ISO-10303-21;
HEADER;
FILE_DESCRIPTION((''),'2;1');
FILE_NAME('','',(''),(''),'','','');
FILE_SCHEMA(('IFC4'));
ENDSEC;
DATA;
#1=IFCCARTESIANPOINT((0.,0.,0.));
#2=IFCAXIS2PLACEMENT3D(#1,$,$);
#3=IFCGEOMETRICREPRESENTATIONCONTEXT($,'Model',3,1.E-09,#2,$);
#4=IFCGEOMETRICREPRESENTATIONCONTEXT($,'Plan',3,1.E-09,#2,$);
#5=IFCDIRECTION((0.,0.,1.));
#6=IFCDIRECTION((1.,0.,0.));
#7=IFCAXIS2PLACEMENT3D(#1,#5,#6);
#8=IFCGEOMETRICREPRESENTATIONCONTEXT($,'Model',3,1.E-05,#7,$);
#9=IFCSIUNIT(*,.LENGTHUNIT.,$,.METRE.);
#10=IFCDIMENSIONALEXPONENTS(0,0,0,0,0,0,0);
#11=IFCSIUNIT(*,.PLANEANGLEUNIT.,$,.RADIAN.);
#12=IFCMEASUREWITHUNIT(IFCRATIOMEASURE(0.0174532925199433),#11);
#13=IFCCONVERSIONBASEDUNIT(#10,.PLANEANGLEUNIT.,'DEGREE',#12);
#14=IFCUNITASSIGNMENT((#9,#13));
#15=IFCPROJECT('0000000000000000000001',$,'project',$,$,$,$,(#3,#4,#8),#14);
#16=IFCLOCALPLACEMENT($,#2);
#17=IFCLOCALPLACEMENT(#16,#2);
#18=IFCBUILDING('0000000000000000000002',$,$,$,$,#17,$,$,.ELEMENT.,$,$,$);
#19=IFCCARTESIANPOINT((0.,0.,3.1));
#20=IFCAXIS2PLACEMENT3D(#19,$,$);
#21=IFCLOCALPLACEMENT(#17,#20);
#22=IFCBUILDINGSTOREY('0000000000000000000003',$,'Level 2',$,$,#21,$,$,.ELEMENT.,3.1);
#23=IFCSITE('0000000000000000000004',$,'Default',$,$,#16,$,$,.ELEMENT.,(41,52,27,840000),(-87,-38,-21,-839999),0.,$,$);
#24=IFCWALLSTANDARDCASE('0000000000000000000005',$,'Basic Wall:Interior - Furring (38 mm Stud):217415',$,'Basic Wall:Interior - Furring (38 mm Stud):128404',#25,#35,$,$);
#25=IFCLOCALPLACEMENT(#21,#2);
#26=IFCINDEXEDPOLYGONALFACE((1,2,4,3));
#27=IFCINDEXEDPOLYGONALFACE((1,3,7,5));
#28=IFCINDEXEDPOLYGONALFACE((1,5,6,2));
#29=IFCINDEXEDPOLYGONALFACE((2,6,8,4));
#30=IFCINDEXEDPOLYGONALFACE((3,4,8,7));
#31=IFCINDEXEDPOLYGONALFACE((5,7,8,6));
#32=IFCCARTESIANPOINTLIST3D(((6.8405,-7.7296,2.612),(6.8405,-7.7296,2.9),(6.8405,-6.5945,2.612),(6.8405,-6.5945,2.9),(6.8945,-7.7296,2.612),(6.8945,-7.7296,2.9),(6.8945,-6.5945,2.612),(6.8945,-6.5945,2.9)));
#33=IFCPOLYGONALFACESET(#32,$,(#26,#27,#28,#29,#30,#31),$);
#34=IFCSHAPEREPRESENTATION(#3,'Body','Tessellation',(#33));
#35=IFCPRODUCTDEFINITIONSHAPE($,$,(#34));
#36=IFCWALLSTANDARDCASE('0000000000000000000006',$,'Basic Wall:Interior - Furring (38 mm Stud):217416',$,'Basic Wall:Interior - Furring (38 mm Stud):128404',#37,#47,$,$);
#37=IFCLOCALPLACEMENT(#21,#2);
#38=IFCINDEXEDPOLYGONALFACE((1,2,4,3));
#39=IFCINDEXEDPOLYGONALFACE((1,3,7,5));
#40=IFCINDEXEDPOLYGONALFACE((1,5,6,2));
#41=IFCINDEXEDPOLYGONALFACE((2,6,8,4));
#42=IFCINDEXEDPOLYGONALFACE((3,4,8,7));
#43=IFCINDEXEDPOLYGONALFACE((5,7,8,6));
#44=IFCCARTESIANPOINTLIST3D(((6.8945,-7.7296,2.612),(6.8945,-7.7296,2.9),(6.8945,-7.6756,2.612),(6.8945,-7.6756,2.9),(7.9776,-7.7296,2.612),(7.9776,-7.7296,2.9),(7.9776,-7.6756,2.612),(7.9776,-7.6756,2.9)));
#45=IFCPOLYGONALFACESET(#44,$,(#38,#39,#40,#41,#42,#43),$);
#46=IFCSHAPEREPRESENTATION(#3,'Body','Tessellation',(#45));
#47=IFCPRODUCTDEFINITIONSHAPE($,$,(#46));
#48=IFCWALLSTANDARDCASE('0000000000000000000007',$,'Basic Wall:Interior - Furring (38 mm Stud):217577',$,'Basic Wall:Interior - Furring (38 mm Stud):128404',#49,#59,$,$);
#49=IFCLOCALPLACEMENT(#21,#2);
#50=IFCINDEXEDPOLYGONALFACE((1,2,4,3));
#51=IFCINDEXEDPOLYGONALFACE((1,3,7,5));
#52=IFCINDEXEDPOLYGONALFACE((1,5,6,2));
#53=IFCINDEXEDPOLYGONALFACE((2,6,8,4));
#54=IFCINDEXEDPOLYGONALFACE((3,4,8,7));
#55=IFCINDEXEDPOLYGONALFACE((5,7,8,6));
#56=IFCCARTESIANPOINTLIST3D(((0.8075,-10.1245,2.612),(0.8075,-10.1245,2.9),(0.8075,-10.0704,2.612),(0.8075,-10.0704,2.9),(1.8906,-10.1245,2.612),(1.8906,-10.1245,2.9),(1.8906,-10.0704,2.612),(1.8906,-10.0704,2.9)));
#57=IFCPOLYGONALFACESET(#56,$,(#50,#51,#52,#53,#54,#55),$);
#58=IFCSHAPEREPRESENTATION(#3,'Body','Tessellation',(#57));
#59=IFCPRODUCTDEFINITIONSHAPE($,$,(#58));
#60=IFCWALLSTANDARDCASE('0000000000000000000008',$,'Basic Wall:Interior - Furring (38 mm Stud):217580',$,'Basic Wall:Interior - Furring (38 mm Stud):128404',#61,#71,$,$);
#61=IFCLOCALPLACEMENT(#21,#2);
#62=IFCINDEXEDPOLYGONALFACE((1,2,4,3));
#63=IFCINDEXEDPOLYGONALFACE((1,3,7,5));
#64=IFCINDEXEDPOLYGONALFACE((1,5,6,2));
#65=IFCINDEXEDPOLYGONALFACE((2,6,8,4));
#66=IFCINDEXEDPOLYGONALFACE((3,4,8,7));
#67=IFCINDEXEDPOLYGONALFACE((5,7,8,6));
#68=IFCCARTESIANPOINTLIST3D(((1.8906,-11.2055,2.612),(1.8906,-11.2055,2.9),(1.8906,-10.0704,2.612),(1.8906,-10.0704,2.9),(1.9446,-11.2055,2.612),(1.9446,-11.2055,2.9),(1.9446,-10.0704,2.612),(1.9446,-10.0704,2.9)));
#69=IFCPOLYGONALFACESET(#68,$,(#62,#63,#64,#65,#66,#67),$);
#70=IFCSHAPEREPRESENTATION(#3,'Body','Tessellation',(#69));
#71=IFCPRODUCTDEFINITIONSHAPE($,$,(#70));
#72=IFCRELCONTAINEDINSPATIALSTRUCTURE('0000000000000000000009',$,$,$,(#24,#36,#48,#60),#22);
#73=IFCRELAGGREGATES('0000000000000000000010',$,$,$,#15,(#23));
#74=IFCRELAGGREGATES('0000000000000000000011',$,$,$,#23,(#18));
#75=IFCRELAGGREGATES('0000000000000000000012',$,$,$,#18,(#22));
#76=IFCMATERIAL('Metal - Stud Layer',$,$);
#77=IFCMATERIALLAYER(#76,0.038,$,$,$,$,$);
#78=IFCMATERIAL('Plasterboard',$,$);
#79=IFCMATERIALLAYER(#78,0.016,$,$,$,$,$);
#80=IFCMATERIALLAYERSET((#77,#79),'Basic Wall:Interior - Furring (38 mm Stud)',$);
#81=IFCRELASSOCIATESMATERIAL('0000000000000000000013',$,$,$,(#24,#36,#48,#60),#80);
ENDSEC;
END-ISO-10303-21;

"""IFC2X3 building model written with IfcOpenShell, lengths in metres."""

from ifc_helpers import new_model, entity, si_unit, converted_unit, frame, frame_2d, origin, origin_with_axes, place, context, project, spatial, rectangle, extrude, material, layer, layer_set, layer_usage, element, save


model = new_model("IFC2X3")

# Units and contexts
model_context_1 = context("Model", 3, precision=1e-09, world=origin())
plan_context = context("Plan", 3, precision=1e-09, world=origin())
model_context_2 = context("Model", 3, precision=1e-05, world=origin_with_axes())
ifc_project = project(units=[si_unit("LENGTHUNIT", "METRE"), converted_unit("PLANEANGLEUNIT", "DEGREE", entity("IfcRatioMeasure", 0.0174532925199433), si_unit("PLANEANGLEUNIT", "RADIAN"), dimensions=[0, 0, 0, 0, 0, 0, 0])], contexts=[model_context_1, plan_context, model_context_2])

# Site, building, storey
site_placement = place(None, origin())
site = spatial("IfcSite", under=ifc_project, at=site_placement, Name="Default", CompositionType="ELEMENT", RefLatitude=(41, 52, 27, 840000), RefLongitude=(-87, -38, -21, -839999), RefElevation=0.0)
building_placement = place(site_placement, origin())
building = spatial("IfcBuilding", under=site, at=building_placement, CompositionType="ELEMENT")
storey_placement = place(building_placement, frame((0.0, 0.0, 3.1)))
storey = spatial("IfcBuildingStorey", under=building, at=storey_placement, Name="Level 2", CompositionType="ELEMENT", Elevation=3.1)

# Shared definitions
ifc_material_1 = material(Name="Plasterboard")
ifc_material_2 = material(Name="Metal - Stud Layer")

# Walls
ifc_layer_1 = layer(ifc_material_2, 0.038)
ifc_layer_2 = layer(ifc_material_1, 0.016)
ifc_layer_set_1 = layer_set([ifc_layer_1, ifc_layer_2], Name="Basic Wall:Interior - Furring (38 mm Stud)")
ifc_layer_usage_1 = layer_usage(ifc_layer_set_1, "AXIS2", "NEGATIVE", 0.027)
wall_1_placement = place(storey_placement, frame((6.8675, -7.7296, 2.612), z_axis=(0.0, 0.0, 1.0), x_axis=(0.0, 1.0, 0.0)))
element("IfcWallStandardCase", 1, at=wall_1_placement, inside=storey, material=ifc_layer_usage_1, Name="Basic Wall:Interior - Furring (38 mm Stud):217415", ObjectType="Basic Wall:Interior - Furring (38 mm Stud):128404", context=model_context_1, shape_type="SweptSolid", body=[
    extrude(rectangle(XDim=1.1351, YDim=0.054, at=frame_2d((0.5675, 0.0), x_axis=(-1.0, 0.0))), origin(), (0.0, 0.0, 1.0), 0.288),
])
ifc_layer_usage_2 = layer_usage(ifc_layer_set_1, "AXIS2", "NEGATIVE", 0.027)
wall_2_placement = place(storey_placement, frame((7.9776, -7.7026, 2.612), z_axis=(0.0, 0.0, 1.0), x_axis=(-1.0, 0.0, 0.0)))
element("IfcWallStandardCase", 2, at=wall_2_placement, inside=storey, material=ifc_layer_usage_2, Name="Basic Wall:Interior - Furring (38 mm Stud):217416", ObjectType="Basic Wall:Interior - Furring (38 mm Stud):128404", context=model_context_1, shape_type="SweptSolid", body=[
    extrude(rectangle(XDim=1.0831, YDim=0.054, at=frame_2d((0.5415, 0.0), x_axis=(-1.0, 0.0))), origin(), (0.0, 0.0, 1.0), 0.288),
])
ifc_layer_usage_3 = layer_usage(ifc_layer_set_1, "AXIS2", "NEGATIVE", 0.027)
wall_3_placement = place(storey_placement, frame((0.8075, -10.0975, 2.612)))
element("IfcWallStandardCase", 3, at=wall_3_placement, inside=storey, material=ifc_layer_usage_3, Name="Basic Wall:Interior - Furring (38 mm Stud):217577", ObjectType="Basic Wall:Interior - Furring (38 mm Stud):128404", context=model_context_1, shape_type="SweptSolid", body=[
    extrude(rectangle(XDim=1.0831, YDim=0.054, at=frame_2d((0.5415, 0.0), x_axis=(-1.0, 0.0))), origin(), (0.0, 0.0, 1.0), 0.288),
])
ifc_layer_usage_4 = layer_usage(ifc_layer_set_1, "AXIS2", "NEGATIVE", 0.027)
wall_4_placement = place(storey_placement, frame((1.9176, -10.0704, 2.612), z_axis=(0.0, 0.0, 1.0), x_axis=(0.0, -1.0, 0.0)))
element("IfcWallStandardCase", 4, at=wall_4_placement, inside=storey, material=ifc_layer_usage_4, Name="Basic Wall:Interior - Furring (38 mm Stud):217580", ObjectType="Basic Wall:Interior - Furring (38 mm Stud):128404", context=model_context_1, shape_type="SweptSolid", body=[
    extrude(rectangle(XDim=1.1351, YDim=0.054, at=frame_2d((0.5675, 0.0), x_axis=(-1.0, 0.0))), origin(), (0.0, 0.0, 1.0), 0.288),
])

save(model, "model.ifc")
